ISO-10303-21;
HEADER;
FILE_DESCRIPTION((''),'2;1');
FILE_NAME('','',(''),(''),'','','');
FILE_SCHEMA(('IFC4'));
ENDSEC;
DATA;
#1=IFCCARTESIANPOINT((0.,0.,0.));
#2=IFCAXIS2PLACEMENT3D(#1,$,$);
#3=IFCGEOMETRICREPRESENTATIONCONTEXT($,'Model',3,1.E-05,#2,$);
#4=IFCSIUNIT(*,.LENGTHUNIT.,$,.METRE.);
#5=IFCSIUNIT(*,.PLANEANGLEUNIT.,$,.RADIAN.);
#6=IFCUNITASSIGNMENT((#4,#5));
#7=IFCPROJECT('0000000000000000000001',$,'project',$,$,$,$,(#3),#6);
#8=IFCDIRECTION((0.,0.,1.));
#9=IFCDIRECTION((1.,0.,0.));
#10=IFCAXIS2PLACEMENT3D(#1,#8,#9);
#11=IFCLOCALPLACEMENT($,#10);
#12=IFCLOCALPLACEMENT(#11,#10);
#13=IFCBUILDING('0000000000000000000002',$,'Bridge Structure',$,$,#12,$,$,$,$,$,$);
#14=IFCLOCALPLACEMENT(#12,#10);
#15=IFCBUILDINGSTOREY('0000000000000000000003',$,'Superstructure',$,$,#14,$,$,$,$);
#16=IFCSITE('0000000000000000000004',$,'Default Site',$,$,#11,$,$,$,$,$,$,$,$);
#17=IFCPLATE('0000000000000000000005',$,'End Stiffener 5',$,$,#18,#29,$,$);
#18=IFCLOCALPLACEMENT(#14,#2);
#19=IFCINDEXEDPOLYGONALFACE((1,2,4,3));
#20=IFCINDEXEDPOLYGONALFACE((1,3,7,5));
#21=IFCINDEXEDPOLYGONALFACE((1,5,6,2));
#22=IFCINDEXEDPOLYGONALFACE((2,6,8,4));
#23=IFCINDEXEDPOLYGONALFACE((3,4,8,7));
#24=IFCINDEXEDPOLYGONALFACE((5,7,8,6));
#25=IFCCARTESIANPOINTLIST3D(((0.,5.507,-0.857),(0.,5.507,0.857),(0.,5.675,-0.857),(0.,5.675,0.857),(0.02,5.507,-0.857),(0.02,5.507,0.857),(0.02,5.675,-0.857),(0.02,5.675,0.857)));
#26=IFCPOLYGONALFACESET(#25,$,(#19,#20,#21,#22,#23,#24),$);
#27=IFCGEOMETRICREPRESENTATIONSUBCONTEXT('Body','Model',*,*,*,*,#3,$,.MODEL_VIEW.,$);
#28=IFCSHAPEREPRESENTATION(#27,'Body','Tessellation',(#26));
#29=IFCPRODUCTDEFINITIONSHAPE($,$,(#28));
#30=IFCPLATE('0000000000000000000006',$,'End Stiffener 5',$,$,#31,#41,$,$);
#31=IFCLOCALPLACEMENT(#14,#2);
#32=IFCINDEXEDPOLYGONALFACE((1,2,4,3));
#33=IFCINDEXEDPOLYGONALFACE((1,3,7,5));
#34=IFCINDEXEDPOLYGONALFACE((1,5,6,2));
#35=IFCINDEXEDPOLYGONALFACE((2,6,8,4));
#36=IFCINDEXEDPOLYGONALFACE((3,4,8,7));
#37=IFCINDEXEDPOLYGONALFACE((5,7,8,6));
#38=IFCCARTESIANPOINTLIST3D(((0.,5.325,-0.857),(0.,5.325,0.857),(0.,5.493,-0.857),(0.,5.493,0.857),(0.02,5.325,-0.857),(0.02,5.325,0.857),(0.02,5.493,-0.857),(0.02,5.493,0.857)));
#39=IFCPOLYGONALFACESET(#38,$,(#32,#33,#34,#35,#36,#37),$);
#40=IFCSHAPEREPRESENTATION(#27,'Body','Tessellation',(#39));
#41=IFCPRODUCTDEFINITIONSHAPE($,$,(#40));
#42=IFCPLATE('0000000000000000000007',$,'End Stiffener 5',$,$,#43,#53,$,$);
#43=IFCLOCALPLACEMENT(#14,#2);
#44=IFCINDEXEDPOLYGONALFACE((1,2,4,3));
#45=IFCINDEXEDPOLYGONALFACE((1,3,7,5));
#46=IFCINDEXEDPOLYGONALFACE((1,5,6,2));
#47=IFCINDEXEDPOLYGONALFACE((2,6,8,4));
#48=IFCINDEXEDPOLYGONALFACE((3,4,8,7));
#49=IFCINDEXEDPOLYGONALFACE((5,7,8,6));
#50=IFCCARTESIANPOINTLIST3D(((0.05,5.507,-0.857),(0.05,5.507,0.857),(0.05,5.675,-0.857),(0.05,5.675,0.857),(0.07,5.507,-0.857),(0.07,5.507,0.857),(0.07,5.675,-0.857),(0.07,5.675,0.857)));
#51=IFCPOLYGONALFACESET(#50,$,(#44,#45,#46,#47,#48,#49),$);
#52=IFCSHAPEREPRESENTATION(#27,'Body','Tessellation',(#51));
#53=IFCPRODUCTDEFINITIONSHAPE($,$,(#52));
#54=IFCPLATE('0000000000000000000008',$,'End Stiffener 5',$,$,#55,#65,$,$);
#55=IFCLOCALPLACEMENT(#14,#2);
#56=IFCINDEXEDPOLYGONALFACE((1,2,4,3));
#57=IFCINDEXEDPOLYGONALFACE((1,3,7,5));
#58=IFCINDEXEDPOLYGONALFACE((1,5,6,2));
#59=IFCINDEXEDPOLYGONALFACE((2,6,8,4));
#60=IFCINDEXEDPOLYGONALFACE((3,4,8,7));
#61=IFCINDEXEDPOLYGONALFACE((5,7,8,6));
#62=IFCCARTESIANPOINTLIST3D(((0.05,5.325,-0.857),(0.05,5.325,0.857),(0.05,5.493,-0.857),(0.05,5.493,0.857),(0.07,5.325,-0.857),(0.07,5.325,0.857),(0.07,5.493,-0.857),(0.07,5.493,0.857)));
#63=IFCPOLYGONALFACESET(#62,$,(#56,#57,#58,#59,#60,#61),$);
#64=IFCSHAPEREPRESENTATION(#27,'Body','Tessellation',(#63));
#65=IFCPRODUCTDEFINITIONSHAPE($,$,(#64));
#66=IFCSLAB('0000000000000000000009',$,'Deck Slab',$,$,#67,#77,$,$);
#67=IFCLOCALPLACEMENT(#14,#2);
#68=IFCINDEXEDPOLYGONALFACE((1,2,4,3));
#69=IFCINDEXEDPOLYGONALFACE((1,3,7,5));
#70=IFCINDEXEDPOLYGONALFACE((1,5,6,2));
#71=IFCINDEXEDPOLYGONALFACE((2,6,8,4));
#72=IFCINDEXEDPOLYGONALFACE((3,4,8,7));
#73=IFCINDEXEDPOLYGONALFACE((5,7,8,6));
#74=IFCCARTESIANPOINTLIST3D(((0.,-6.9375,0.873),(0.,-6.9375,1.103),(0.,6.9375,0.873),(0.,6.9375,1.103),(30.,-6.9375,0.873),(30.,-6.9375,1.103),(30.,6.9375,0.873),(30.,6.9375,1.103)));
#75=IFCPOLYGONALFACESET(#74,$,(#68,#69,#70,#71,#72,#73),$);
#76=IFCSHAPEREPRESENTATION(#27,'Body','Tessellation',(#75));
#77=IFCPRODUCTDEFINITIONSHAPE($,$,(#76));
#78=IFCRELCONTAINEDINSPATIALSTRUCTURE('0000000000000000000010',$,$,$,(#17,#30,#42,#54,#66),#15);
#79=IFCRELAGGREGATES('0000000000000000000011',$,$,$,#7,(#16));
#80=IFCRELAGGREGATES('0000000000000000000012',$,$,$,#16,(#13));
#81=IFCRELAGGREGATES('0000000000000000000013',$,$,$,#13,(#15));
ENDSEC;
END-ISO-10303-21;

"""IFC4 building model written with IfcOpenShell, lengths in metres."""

from ifc_helpers import new_model, si_unit, frame, origin, origin_with_axes, origin_2d_with_axis, place, context, subcontext, project, spatial, polyline, rectangle, outline, extrude, element, save


model = new_model("IFC4")

# Units and contexts
model_context = context("Model", 3, precision=1e-05, world=origin())
body_context = subcontext(model_context, "Body", "Model", "MODEL_VIEW")
ifc_project = project(units=[si_unit("LENGTHUNIT", "METRE"), si_unit("PLANEANGLEUNIT", "RADIAN")], contexts=[model_context])

# Site, building, storey
site_placement = place(None, origin_with_axes())
site = spatial("IfcSite", under=ifc_project, at=site_placement, Name="Default Site")
building_placement = place(site_placement, origin_with_axes())
building = spatial("IfcBuilding", under=site, at=building_placement, Name="Bridge Structure")
storey_placement = place(building_placement, origin_with_axes())
storey = spatial("IfcBuildingStorey", under=building, at=storey_placement, Name="Superstructure")

# Plates
for number, where, z_axis, x_axis, name in (
    (1, (0.01, 5.591, -0.857), (0.0, 0.0, 1.0), (1.0, 0.0, 0.0), "End Stiffener 5"),
    (2, (0.01, 5.409, -0.857), (0.0, 0.0, 1.0), (1.0, 0.0, 0.0), "End Stiffener 5"),
    (3, (0.06, 5.591, -0.857), (0.0, 0.0, 1.0), (1.0, 0.0, 0.0), "End Stiffener 5"),
    (4, (0.06, 5.409, -0.857), (0.0, 0.0, 1.0), (1.0, 0.0, 0.0), "End Stiffener 5"),
):
    element("IfcPlate", number, at=place(storey_placement, frame(where, z_axis=z_axis, x_axis=x_axis)), inside=storey, Name=name, context=body_context, shape_type="SweptSolid", body=[
        extrude(rectangle(XDim=0.02, YDim=0.168, at=origin_2d_with_axis()), origin_with_axes(), (0.0, 0.0, 1.0), 1.714),
    ])

# Slab
slab_placement = place(storey_placement, frame((0.0, 0.0, 0.873), z_axis=(0.0, 0.0, 1.0), x_axis=(1.0, 0.0, 0.0)))
element("IfcSlab", 5, at=slab_placement, inside=storey, Name="Deck Slab", context=body_context, shape_type="SweptSolid", body=[
    extrude(outline(polyline([(0.0, -6.9375), (30.0, -6.9375), (30.0, 6.9375), (0.0, 6.9375), (0.0, -6.9375)])), origin_with_axes(), (0.0, 0.0, 1.0), 0.23),
])

save(model, "model.ifc")
